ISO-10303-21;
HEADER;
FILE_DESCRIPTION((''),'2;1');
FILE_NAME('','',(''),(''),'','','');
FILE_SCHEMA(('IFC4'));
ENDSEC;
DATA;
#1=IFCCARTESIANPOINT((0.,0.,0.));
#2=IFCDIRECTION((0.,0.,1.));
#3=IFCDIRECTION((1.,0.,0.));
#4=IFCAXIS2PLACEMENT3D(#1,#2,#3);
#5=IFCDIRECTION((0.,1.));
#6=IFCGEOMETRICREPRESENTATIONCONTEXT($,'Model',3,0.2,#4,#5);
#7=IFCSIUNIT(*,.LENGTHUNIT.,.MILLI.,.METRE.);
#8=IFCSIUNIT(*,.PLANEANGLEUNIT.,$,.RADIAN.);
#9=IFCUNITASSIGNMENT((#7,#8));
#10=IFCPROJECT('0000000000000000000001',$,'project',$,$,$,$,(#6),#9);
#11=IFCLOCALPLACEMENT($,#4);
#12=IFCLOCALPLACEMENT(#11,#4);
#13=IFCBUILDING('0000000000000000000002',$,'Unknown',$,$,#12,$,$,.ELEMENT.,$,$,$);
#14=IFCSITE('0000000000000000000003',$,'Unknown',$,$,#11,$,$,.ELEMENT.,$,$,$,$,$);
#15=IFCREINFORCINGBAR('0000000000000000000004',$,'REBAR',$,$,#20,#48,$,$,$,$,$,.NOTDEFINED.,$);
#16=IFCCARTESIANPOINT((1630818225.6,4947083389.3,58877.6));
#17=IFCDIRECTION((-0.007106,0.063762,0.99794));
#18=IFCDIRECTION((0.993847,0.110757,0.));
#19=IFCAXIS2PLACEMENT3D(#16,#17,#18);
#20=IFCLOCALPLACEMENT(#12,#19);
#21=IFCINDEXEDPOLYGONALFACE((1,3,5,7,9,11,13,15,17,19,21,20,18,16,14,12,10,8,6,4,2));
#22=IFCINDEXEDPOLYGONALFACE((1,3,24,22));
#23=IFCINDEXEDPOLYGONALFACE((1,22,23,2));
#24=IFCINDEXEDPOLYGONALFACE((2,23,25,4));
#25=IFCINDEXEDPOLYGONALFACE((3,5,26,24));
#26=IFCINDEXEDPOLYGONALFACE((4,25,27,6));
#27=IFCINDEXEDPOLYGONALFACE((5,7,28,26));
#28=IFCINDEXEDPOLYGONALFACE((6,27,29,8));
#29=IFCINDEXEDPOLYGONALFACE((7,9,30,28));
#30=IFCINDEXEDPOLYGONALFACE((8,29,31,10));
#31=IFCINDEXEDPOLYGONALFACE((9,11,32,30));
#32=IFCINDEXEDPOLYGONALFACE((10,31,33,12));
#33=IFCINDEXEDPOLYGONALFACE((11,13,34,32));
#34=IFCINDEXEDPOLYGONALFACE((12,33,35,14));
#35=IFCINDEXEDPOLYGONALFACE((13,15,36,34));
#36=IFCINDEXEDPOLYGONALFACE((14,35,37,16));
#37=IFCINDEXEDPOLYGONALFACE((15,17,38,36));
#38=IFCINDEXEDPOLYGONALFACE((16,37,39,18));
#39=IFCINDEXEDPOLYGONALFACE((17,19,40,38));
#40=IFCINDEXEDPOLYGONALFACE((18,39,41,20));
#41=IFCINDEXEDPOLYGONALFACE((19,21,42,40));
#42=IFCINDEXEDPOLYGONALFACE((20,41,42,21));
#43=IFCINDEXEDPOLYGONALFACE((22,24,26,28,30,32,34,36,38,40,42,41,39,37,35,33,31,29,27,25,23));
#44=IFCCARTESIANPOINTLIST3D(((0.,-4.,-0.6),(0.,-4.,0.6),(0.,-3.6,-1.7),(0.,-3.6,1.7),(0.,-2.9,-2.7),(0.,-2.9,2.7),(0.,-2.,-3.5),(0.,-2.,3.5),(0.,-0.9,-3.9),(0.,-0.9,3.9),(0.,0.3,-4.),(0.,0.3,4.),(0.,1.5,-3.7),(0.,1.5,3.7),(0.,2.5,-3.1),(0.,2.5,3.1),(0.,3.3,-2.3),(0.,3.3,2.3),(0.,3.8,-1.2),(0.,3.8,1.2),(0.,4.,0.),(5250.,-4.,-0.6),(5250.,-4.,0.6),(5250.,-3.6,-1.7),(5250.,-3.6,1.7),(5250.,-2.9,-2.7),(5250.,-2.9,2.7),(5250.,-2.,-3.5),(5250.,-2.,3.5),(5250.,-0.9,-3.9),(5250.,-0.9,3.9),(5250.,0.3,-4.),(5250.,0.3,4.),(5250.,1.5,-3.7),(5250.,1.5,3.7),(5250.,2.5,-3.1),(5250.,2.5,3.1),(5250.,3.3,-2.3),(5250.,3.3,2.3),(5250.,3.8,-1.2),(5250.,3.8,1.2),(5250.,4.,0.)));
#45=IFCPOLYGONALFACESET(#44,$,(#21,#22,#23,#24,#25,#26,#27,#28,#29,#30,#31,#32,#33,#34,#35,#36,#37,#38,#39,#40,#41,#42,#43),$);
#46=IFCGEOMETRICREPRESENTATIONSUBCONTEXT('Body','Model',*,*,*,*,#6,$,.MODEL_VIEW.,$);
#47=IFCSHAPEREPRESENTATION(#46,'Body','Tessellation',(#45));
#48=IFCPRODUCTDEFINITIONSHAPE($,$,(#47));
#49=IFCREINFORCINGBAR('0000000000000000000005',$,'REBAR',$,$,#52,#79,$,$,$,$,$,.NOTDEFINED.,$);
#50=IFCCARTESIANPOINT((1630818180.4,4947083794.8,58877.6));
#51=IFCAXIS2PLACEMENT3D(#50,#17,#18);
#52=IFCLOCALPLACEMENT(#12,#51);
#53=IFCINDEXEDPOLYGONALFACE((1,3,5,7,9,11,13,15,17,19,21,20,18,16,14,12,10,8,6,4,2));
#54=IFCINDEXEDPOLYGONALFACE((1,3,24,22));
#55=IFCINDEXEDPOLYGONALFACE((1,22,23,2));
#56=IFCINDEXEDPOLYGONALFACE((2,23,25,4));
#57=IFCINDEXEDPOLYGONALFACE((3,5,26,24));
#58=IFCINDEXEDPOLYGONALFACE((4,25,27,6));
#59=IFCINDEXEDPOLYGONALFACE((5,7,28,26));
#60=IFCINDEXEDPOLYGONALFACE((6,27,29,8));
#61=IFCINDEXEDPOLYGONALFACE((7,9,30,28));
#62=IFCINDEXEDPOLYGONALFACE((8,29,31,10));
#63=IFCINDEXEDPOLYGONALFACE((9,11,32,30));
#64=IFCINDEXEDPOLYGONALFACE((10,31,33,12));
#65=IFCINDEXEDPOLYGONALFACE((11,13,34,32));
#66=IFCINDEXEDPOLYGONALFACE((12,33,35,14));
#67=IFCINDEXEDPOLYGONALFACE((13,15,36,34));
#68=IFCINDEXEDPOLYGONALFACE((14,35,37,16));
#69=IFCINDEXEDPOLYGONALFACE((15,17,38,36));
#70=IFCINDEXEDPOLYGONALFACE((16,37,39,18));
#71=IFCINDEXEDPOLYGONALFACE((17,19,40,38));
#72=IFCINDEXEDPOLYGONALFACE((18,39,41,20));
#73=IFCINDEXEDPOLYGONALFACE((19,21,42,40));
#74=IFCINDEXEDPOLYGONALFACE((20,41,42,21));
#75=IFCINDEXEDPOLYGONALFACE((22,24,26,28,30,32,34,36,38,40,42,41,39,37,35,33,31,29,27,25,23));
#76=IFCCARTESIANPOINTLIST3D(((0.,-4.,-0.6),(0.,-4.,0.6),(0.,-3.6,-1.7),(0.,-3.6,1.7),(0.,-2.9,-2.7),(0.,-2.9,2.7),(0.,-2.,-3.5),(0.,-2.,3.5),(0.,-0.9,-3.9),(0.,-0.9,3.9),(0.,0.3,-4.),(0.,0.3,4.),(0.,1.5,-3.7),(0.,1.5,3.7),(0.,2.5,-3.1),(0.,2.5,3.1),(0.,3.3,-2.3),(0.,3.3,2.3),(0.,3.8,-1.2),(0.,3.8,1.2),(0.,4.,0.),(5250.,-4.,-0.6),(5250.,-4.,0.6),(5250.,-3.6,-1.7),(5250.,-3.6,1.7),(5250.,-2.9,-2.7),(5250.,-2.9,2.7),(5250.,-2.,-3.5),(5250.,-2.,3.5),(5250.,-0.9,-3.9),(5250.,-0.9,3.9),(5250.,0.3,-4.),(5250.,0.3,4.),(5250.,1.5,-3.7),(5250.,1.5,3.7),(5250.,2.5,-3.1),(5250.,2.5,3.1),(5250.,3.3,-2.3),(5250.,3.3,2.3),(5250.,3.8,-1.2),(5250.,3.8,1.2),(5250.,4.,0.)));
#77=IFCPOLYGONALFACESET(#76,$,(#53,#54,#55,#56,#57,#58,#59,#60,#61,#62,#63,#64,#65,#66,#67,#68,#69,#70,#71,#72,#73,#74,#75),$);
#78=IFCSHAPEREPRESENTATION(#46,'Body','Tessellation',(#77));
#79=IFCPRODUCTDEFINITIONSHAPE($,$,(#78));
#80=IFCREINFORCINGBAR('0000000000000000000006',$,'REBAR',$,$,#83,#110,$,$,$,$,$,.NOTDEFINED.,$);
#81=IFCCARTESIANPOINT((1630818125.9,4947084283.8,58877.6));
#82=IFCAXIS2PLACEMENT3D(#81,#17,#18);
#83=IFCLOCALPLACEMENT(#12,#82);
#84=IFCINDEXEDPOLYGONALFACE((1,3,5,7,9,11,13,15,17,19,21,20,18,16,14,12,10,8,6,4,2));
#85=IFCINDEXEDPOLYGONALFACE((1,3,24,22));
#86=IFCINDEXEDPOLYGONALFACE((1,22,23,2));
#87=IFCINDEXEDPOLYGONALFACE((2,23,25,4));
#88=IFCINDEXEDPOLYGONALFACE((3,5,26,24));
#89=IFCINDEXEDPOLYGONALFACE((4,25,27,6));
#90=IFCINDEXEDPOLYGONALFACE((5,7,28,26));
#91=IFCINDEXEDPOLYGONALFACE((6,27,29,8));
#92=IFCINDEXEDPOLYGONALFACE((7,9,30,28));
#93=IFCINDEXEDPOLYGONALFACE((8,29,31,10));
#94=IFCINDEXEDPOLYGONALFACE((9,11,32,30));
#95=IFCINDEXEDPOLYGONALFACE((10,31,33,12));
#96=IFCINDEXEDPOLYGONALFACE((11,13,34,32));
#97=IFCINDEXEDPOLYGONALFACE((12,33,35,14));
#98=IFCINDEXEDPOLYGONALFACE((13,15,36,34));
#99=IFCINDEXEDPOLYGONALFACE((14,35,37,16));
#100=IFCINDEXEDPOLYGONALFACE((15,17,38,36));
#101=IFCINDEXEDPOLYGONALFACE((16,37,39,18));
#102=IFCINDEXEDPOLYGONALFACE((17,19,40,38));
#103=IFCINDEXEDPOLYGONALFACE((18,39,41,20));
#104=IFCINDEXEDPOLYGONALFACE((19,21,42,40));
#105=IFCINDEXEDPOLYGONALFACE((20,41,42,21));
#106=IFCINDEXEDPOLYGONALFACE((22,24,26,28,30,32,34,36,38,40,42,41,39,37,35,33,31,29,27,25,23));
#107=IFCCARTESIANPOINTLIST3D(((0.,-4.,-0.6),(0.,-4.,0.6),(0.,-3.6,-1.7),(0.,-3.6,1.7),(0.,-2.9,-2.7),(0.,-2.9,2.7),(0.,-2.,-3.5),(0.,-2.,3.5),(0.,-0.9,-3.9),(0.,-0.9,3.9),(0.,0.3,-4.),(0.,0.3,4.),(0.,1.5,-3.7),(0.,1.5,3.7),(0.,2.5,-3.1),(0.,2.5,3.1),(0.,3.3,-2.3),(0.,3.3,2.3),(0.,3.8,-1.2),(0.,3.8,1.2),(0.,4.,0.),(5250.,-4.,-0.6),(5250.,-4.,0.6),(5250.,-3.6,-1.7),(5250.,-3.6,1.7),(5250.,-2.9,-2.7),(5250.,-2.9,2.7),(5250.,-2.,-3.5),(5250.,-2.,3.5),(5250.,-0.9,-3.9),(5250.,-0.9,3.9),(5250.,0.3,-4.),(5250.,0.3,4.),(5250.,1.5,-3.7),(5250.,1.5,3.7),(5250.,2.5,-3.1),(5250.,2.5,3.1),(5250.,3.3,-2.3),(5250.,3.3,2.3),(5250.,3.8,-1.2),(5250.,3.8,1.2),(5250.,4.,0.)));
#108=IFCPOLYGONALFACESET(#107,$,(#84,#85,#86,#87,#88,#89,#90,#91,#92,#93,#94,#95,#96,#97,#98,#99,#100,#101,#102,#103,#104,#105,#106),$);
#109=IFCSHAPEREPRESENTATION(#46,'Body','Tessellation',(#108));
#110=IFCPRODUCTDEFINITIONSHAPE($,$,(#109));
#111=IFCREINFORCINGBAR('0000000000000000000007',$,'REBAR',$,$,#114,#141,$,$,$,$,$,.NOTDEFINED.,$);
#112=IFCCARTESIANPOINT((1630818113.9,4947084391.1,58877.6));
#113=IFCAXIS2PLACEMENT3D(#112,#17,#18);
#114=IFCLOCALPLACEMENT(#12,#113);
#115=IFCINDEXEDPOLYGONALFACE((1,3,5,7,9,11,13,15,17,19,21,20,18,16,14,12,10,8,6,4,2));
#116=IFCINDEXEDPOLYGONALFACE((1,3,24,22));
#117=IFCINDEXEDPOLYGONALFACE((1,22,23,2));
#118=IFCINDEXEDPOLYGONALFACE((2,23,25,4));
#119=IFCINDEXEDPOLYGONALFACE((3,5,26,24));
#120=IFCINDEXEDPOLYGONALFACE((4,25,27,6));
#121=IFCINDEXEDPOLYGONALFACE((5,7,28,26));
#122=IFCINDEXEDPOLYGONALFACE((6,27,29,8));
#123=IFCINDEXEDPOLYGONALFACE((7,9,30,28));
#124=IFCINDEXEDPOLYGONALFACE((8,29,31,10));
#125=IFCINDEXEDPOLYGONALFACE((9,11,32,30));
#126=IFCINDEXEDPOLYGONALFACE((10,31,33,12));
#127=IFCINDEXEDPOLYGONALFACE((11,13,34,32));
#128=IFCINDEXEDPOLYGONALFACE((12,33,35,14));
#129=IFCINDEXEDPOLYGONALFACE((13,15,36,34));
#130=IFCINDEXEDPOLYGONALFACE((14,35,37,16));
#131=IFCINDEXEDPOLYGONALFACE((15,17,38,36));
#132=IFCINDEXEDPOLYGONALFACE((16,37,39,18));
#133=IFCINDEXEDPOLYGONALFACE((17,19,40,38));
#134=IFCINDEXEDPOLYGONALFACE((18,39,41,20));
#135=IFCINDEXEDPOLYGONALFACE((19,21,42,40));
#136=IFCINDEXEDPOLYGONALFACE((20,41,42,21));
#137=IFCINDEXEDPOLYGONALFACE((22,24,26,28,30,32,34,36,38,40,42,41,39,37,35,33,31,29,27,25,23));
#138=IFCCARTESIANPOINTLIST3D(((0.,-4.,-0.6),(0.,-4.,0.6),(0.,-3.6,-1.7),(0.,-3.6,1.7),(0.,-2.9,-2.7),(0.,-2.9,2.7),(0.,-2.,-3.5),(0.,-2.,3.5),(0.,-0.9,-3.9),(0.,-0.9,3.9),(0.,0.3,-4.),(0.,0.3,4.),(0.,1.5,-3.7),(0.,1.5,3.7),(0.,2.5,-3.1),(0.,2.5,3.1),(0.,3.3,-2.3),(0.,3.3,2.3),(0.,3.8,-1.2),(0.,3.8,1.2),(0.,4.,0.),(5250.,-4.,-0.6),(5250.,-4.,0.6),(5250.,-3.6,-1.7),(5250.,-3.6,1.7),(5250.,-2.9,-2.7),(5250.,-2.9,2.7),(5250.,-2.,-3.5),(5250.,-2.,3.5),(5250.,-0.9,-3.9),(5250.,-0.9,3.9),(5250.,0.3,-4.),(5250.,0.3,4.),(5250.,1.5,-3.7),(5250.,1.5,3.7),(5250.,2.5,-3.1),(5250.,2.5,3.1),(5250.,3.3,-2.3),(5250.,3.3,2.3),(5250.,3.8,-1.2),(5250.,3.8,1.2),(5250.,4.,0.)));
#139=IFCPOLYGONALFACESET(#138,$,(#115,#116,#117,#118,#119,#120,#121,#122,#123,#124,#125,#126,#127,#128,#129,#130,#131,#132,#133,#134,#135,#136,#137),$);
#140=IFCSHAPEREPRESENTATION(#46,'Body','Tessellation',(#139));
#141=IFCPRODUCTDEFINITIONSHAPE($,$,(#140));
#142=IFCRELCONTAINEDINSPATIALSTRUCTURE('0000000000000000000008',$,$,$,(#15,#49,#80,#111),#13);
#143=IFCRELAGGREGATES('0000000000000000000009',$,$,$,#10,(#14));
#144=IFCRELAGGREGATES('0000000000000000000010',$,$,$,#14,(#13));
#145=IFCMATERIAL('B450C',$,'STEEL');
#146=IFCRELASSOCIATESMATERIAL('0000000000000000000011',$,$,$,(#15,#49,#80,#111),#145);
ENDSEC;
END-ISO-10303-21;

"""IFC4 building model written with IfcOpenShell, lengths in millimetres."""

from ifc_helpers import new_model, entity, si_unit, direction, frame, origin_with_axes, place, context, subcontext, project, spatial, material, element, save


model = new_model("IFC4")

# Units and contexts
model_context = context("Model", 3, precision=0.2, world=origin_with_axes(), true_north=direction((0.0, 1.0)))
body_context = subcontext(model_context, "Body", "Model", "MODEL_VIEW")
ifc_project = project(units=[si_unit("LENGTHUNIT", "METRE", prefix="MILLI"), si_unit("PLANEANGLEUNIT", "RADIAN")], contexts=[model_context])

# Site, building
site_placement = place(None, origin_with_axes())
site = spatial("IfcSite", under=ifc_project, at=site_placement, Name="Unknown", CompositionType="ELEMENT")
building_placement = place(site_placement, origin_with_axes())
building = spatial("IfcBuilding", under=site, at=building_placement, Name="Unknown", CompositionType="ELEMENT")

# Reinforcing bars
ifc_material = material(Name="B450C", Category="STEEL")
for number, where, z_axis, x_axis, name in (
    (1, (1630818225.6, 4947083389.3, 58877.6), (-0.007106, 0.063762, 0.99794), (0.993847, 0.110757, 0.0), "REBAR"),
    (2, (1630818180.4, 4947083794.8, 58877.6), (-0.007106, 0.063762, 0.99794), (0.993847, 0.110757, 0.0), "REBAR"),
    (3, (1630818125.9, 4947084283.8, 58877.6), (-0.007106, 0.063762, 0.99794), (0.993847, 0.110757, 0.0), "REBAR"),
    (4, (1630818113.9, 4947084391.1, 58877.6), (-0.007106, 0.063762, 0.99794), (0.993847, 0.110757, 0.0), "REBAR"),
):
    element("IfcReinforcingBar", number, at=place(building_placement, frame(where, z_axis=z_axis, x_axis=x_axis)), inside=building, material=ifc_material, Name=name, PredefinedType="NOTDEFINED", context=body_context, shape_type="AdvancedSweptSolid", body=[
        entity("IfcSweptDiskSolid", entity("IfcIndexedPolyCurve", entity("IfcCartesianPointList3D", [[0.0, 0.0, 0.0], [5250.0, 0.0, 0.0]]), [entity("IfcLineIndex", [1, 2])]), 4.0),
    ])

save(model, "model.ifc")
